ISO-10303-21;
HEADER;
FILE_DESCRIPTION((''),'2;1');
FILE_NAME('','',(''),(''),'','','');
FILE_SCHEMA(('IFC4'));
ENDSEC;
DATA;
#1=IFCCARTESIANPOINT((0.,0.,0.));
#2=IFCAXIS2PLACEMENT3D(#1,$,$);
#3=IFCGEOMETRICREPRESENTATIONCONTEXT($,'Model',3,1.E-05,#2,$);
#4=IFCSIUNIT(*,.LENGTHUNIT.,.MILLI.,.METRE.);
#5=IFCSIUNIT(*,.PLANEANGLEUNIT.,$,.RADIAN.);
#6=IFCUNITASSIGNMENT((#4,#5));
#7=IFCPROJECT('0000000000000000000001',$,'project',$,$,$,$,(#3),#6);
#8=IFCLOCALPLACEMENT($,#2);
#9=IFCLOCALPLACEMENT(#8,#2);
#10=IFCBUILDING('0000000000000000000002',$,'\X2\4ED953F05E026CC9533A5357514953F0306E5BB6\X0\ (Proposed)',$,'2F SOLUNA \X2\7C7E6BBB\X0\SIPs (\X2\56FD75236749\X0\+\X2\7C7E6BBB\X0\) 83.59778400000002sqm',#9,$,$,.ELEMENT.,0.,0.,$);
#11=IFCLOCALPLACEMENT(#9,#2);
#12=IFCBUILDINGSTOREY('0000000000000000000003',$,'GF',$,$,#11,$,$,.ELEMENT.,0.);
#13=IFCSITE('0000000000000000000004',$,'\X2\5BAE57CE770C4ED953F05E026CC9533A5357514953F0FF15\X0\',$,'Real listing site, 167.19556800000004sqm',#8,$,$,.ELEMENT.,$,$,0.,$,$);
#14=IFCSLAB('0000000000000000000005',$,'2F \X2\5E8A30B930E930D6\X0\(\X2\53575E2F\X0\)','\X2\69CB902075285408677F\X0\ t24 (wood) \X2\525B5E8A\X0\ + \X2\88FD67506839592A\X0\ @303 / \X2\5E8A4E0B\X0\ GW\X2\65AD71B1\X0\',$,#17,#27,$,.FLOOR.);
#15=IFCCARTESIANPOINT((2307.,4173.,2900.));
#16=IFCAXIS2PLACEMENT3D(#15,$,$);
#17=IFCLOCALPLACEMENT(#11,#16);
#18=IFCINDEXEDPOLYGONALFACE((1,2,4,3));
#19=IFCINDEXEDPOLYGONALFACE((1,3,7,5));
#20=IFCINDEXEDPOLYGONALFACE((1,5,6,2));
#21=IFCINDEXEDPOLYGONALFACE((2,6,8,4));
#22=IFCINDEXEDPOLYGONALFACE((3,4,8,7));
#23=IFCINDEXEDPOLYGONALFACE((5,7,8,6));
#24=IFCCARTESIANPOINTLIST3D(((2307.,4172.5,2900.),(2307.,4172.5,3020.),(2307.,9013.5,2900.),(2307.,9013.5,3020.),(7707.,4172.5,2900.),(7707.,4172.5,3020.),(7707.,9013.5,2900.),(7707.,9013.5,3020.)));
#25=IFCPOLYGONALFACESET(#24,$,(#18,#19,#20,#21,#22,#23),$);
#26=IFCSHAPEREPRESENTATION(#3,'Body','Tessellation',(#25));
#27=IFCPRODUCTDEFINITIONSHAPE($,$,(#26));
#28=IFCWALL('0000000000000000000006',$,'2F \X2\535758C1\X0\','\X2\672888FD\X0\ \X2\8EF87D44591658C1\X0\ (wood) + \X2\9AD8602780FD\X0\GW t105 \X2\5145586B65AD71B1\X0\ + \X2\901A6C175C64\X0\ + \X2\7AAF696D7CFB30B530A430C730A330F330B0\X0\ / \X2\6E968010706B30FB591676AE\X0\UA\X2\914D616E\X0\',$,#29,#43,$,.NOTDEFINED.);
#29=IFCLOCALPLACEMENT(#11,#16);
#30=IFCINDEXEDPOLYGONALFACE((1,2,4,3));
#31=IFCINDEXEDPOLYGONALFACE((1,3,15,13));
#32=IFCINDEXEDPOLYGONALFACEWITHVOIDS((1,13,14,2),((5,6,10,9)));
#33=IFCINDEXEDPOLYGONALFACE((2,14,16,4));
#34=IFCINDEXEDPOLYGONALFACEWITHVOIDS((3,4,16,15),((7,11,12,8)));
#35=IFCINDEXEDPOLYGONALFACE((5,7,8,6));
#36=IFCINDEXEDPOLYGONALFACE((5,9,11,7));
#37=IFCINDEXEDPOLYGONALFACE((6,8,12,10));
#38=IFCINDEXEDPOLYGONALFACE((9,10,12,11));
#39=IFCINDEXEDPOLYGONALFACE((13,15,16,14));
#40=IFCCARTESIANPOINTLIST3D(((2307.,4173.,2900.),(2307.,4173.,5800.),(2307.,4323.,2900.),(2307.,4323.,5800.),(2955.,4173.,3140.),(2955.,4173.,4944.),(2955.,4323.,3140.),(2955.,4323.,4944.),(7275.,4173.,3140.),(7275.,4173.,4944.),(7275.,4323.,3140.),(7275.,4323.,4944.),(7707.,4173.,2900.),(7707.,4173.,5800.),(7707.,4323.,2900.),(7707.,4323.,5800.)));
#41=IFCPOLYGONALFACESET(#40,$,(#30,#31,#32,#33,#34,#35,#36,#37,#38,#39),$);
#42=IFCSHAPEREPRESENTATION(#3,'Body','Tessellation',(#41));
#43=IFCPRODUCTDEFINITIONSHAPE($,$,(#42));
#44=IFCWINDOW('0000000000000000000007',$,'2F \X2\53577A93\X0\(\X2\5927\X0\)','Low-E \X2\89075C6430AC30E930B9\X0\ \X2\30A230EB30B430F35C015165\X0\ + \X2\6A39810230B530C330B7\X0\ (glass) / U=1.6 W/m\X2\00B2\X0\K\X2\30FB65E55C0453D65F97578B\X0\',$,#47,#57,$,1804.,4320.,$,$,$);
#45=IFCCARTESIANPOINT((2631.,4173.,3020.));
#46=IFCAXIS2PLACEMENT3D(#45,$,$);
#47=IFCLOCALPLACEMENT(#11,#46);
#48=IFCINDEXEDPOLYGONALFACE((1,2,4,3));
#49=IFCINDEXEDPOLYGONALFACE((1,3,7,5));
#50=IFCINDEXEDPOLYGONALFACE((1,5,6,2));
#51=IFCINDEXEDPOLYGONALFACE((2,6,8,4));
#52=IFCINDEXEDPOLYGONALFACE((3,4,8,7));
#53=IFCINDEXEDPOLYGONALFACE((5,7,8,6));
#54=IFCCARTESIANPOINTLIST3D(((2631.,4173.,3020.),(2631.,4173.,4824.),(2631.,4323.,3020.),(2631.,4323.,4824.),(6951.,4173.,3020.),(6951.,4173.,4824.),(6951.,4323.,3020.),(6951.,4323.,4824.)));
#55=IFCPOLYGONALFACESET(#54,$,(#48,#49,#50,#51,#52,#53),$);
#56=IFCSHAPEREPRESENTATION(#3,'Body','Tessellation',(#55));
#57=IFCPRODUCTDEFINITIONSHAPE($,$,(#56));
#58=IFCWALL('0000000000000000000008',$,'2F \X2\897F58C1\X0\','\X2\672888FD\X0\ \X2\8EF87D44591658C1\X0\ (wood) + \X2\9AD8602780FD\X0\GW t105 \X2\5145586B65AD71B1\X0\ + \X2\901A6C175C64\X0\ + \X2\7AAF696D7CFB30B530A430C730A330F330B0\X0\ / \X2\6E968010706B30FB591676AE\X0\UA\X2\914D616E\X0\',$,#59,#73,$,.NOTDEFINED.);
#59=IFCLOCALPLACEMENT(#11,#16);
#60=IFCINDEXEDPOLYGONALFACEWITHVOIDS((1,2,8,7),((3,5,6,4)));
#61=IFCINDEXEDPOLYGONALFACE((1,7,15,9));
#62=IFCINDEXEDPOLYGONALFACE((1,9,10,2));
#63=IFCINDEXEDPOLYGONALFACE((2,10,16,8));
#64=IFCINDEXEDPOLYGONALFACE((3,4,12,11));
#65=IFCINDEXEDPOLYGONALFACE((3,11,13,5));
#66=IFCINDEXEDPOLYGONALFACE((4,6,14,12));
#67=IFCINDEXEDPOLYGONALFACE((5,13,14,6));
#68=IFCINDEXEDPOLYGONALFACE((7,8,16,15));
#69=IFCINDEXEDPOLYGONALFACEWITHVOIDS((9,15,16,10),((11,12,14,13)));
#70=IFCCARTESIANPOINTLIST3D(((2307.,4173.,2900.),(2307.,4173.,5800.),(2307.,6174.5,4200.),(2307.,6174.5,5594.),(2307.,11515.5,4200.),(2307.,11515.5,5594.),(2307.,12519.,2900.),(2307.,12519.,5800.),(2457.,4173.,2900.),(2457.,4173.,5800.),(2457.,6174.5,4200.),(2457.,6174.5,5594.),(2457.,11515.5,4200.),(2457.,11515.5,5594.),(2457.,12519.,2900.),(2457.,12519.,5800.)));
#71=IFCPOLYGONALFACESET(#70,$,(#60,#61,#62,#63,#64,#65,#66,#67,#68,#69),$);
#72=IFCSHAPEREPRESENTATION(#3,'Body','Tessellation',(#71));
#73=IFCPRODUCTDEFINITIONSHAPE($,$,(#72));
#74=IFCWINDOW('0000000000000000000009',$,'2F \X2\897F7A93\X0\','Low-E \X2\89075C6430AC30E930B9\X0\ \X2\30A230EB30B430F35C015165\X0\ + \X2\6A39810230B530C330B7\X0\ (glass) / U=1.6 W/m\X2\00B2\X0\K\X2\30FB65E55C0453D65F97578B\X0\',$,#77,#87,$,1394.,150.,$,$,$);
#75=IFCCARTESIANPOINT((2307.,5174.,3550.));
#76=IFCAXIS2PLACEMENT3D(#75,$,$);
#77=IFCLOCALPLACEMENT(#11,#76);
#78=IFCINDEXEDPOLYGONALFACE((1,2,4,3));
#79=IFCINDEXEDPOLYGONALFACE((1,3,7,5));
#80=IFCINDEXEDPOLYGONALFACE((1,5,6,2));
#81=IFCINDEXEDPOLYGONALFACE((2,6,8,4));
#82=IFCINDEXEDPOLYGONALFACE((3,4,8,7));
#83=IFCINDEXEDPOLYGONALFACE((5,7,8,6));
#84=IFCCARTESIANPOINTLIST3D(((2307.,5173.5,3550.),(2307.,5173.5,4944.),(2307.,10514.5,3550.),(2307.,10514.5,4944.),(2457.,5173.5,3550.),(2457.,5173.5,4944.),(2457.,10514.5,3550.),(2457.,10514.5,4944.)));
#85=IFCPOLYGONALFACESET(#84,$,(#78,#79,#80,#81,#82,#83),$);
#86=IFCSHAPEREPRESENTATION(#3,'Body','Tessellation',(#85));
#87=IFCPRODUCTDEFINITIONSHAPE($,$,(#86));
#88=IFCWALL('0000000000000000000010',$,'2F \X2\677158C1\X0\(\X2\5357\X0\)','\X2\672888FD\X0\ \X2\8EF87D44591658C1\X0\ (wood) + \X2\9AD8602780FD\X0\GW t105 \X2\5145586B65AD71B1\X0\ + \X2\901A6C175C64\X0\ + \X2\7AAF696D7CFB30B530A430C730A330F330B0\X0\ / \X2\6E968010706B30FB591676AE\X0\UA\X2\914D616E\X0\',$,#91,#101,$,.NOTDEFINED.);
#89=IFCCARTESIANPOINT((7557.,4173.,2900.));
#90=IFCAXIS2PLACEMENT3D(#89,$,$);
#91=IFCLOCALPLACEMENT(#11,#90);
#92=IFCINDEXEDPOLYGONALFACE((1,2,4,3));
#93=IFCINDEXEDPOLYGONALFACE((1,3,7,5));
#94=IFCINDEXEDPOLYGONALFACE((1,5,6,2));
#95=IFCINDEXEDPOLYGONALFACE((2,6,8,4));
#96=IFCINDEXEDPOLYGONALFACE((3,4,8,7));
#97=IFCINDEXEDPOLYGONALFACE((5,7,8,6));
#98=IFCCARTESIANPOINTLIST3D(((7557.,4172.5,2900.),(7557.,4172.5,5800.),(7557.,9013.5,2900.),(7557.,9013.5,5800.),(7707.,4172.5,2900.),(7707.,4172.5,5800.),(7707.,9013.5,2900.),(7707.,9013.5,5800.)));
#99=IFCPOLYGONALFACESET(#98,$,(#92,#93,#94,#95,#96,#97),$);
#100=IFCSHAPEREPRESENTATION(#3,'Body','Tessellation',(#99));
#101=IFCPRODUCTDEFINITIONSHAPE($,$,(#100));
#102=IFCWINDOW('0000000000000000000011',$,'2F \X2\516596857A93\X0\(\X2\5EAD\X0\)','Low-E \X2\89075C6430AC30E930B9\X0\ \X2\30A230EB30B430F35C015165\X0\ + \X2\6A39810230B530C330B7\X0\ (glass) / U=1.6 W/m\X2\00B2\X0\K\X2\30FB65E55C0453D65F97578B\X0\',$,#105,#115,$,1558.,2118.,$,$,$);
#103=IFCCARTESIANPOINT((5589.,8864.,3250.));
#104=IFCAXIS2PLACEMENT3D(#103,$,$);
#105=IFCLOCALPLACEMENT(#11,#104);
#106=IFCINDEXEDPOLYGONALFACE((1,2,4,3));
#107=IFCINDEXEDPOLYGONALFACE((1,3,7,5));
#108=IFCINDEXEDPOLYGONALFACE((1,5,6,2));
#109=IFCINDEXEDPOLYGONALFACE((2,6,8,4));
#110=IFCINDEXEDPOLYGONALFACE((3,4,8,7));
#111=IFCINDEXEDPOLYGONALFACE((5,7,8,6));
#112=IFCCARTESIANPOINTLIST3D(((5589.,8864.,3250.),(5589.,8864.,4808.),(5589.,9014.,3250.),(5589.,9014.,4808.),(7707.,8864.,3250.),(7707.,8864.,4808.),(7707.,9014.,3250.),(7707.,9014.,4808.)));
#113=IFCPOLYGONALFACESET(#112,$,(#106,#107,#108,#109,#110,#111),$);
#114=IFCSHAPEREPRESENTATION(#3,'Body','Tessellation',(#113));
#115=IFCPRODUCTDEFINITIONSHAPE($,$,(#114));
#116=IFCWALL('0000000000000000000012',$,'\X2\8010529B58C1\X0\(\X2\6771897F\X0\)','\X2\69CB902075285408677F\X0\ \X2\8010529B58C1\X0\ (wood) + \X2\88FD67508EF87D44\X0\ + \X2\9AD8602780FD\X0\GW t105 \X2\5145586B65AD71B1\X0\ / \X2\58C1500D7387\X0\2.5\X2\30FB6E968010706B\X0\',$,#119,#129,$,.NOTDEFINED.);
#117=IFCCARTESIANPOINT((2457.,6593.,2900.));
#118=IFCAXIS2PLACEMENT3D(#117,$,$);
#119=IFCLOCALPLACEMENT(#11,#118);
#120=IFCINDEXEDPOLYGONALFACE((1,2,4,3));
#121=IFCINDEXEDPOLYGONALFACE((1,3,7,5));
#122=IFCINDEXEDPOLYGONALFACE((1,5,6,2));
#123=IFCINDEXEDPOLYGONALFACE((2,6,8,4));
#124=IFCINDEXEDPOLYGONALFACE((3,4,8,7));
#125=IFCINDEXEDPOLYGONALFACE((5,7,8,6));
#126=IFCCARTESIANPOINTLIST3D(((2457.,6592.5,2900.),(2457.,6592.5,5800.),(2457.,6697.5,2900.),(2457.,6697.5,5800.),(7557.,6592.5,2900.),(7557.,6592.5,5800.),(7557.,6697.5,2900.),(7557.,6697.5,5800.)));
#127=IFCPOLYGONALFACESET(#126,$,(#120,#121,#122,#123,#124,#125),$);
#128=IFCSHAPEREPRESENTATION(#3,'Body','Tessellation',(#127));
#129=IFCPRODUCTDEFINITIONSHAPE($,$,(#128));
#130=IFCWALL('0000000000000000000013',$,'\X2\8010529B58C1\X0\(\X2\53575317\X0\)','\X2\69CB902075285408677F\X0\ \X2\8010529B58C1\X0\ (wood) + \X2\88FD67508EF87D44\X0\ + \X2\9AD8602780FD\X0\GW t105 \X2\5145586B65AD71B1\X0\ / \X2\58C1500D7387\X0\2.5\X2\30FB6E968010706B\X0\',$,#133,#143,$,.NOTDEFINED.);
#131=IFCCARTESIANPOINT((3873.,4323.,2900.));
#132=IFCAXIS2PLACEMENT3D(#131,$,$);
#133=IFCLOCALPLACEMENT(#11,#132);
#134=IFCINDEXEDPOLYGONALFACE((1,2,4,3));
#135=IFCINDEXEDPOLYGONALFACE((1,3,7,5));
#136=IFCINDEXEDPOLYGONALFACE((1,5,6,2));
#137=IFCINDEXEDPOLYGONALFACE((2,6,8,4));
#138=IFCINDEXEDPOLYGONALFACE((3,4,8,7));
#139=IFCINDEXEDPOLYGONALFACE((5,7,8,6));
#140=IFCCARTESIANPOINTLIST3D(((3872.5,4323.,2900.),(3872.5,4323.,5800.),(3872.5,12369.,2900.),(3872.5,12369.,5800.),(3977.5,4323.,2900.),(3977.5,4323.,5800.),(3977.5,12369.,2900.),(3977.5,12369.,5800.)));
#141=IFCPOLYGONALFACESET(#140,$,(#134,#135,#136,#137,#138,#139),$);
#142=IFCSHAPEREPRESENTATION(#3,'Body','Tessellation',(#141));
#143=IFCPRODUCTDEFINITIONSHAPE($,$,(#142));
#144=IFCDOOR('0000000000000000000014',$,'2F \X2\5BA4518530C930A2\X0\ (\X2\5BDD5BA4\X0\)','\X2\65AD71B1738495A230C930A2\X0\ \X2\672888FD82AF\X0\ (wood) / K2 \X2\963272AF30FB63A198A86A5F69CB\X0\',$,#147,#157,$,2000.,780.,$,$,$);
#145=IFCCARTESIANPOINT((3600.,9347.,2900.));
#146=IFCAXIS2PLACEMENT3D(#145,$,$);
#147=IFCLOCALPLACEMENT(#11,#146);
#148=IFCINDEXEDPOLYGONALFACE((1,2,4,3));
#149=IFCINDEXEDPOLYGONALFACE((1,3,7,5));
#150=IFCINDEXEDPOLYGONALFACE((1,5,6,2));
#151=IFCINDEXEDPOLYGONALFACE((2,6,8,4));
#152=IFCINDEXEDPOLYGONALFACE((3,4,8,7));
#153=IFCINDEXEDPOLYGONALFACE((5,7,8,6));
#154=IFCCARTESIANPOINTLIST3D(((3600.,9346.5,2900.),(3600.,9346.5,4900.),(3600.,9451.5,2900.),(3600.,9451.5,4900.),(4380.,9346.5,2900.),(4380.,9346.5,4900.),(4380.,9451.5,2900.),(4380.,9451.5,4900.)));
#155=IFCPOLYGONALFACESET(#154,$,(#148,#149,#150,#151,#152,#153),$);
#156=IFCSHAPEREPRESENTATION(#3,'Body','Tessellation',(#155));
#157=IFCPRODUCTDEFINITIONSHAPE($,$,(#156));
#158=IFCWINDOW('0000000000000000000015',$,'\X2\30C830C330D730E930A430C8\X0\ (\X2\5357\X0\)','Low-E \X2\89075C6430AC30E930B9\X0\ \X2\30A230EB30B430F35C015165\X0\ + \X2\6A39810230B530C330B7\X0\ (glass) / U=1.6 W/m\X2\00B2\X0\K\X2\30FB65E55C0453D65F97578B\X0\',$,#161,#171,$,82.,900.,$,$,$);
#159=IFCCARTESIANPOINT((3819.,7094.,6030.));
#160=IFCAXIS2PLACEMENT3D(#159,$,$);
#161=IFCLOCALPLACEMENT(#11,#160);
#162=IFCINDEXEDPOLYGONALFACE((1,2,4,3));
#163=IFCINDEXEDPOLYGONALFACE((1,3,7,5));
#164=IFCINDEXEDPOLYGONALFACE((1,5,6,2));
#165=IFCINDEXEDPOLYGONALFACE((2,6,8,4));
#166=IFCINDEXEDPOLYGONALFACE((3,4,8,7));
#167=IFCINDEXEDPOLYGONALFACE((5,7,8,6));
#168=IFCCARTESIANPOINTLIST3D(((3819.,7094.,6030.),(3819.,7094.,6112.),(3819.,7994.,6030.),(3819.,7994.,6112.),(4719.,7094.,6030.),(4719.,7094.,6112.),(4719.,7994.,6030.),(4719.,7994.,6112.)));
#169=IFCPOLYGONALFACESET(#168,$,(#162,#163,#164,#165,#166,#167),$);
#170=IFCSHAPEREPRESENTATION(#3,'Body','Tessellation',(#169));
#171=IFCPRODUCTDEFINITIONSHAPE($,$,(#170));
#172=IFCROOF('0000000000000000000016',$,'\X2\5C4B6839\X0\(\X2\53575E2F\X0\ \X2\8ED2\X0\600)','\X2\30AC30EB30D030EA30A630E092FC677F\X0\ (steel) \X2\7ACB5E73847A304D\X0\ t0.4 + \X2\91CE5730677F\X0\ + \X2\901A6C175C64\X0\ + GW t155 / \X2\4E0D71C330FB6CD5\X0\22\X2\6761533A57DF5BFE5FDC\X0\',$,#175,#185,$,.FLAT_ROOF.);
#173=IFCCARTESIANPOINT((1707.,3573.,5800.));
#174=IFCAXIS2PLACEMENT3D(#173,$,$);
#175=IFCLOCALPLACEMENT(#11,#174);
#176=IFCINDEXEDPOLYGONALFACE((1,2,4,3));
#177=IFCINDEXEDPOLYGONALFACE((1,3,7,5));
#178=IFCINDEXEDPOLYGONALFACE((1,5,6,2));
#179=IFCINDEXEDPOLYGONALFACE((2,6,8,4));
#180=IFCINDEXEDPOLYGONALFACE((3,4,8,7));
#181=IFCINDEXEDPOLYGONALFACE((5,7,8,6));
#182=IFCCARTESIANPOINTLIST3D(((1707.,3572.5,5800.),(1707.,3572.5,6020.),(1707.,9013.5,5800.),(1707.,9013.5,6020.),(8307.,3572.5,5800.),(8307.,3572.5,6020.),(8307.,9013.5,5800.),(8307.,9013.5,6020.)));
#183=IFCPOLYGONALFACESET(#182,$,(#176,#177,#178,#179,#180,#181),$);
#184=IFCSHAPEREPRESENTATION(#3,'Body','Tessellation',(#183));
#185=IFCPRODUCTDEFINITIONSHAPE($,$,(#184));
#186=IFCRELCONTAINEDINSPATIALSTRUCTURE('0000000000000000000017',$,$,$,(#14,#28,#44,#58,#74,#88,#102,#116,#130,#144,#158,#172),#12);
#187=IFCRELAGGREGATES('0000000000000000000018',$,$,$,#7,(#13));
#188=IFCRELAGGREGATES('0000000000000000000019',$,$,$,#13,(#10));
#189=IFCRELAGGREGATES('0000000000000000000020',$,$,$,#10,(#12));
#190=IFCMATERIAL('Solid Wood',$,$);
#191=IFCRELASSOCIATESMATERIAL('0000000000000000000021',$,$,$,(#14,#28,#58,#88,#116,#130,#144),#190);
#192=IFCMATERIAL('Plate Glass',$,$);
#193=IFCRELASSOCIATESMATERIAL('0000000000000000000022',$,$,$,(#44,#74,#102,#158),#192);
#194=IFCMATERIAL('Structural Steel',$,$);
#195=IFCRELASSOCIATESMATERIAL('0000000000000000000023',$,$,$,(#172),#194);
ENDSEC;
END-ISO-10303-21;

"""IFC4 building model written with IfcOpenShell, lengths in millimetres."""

from ifc_helpers import new_model, si_unit, frame, frame_2d, origin, place, context, project, spatial, rectangle, extrude, material, element, fill, save


model = new_model("IFC4")

# Units and contexts
model_context = context("Model", 3, precision=1e-05, world=origin())
ifc_project = project(units=[si_unit("LENGTHUNIT", "METRE", prefix="MILLI"), si_unit("PLANEANGLEUNIT", "RADIAN")], contexts=[model_context])

# Site, building, storey
site_placement = place(None, origin())
site = spatial("IfcSite", under=ifc_project, at=site_placement, Name="宮城県仙台市泉区南光台５", ObjectType="Real listing site, 167.19556800000004sqm", CompositionType="ELEMENT", RefElevation=0.0)
building_placement = place(site_placement, origin())
building = spatial("IfcBuilding", under=site, at=building_placement, Name="仙台市泉区南光台の家 (Proposed)", ObjectType="2F SOLUNA 籾殻SIPs (国産杉+籾殻) 83.59778400000002sqm", CompositionType="ELEMENT", ElevationOfRefHeight=0.0, ElevationOfTerrain=0.0)
storey_placement = place(building_placement, origin())
storey = spatial("IfcBuildingStorey", under=building, at=storey_placement, Name="GF", CompositionType="ELEMENT", Elevation=0.0)

# Slab
ifc_material_1 = material(Name="Solid Wood")
slab_placement = place(storey_placement, frame((2307.0, 4173.0, 2900.0)))
element("IfcSlab", 1, at=slab_placement, inside=storey, material=ifc_material_1, Name="2F 床スラブ(南帯)", Description="構造用合板 t24 (wood) 剛床 + 製材根太 @303 / 床下 GW断熱", PredefinedType="FLOOR", context=model_context, shape_type="SweptSolid", body=[
    extrude(rectangle(XDim=5400.0, YDim=4841.0, at=frame_2d((2700.0, 2420.0))), frame((2307.0, 4173.0, 2900.0)), (0.0, 0.0, 1.0), 120.0),
])

# Walls, openings, windows
wall_1_placement = place(storey_placement, frame((2307.0, 4173.0, 2900.0)))
wall_1 = element("IfcWall", 2, at=wall_1_placement, inside=storey, material=ifc_material_1, Name="2F 南壁", Description="木製 軸組外壁 (wood) + 高性能GW t105 充填断熱 + 通気層 + 窯業系サイディング / 準耐火・外皮UA配慮", PredefinedType="NOTDEFINED", context=model_context, shape_type="SweptSolid", body=[
    extrude(rectangle(XDim=5400.0, YDim=150.0, at=frame_2d((2700.0, 75.0))), frame((2307.0, 4173.0, 2900.0)), (0.0, 0.0, 1.0), 2900.0),
])
opening_1_placement = place(storey_placement, frame((2631.0, 4173.0, 3020.0)))
opening_1 = element("IfcOpeningElement", 3, at=opening_1_placement, cuts=wall_1, PredefinedType="NOTDEFINED", context=model_context, shape_type="SweptSolid", body=[
    extrude(rectangle(XDim=4320.0, YDim=150.0, at=frame_2d((2160.0, 75.0))), frame((2631.0, 4173.0, 3020.0)), (0.0, 0.0, 1.0), 1804.0),
])
ifc_material_2 = material(Name="Plate Glass")
window_1_placement = place(storey_placement, frame((2631.0, 4173.0, 3020.0)))
window_1 = element("IfcWindow", 4, at=window_1_placement, inside=storey, material=ifc_material_2, Name="2F 南窓(大)", Description="Low-E 複層ガラス アルゴン封入 + 樹脂サッシ (glass) / U=1.6 W/m²K・日射取得型", OverallHeight=1804.0, OverallWidth=4320.0, context=model_context, shape_type="SweptSolid", body=[
    extrude(rectangle(XDim=4320.0, YDim=150.0, at=frame_2d((2160.0, 75.0))), frame((2631.0, 4173.0, 3020.0)), (0.0, 0.0, 1.0), 1804.0),
])
fill(opening_1, window_1)
wall_2_placement = place(storey_placement, frame((2307.0, 4173.0, 2900.0)))
wall_2 = element("IfcWall", 5, at=wall_2_placement, inside=storey, material=ifc_material_1, Name="2F 西壁", Description="木製 軸組外壁 (wood) + 高性能GW t105 充填断熱 + 通気層 + 窯業系サイディング / 準耐火・外皮UA配慮", PredefinedType="NOTDEFINED", context=model_context, shape_type="SweptSolid", body=[
    extrude(rectangle(XDim=150.0, YDim=8346.0, at=frame_2d((75.0, 4173.0))), frame((2307.0, 4173.0, 2900.0)), (0.0, 0.0, 1.0), 2900.0),
])
opening_2_placement = place(storey_placement, frame((2307.0, 5174.0, 3550.0)))
opening_2 = element("IfcOpeningElement", 6, at=opening_2_placement, cuts=wall_2, PredefinedType="NOTDEFINED", context=model_context, shape_type="SweptSolid", body=[
    extrude(rectangle(XDim=150.0, YDim=5341.0, at=frame_2d((75.0, 2670.0))), frame((2307.0, 5174.0, 3550.0)), (0.0, 0.0, 1.0), 1394.0),
])
window_2_placement = place(storey_placement, frame((2307.0, 5174.0, 3550.0)))
window_2 = element("IfcWindow", 7, at=window_2_placement, inside=storey, material=ifc_material_2, Name="2F 西窓", Description="Low-E 複層ガラス アルゴン封入 + 樹脂サッシ (glass) / U=1.6 W/m²K・日射取得型", OverallHeight=1394.0, OverallWidth=150.0, context=model_context, shape_type="SweptSolid", body=[
    extrude(rectangle(XDim=150.0, YDim=5341.0, at=frame_2d((75.0, 2670.0))), frame((2307.0, 5174.0, 3550.0)), (0.0, 0.0, 1.0), 1394.0),
])
fill(opening_2, window_2)
wall_3_placement = place(storey_placement, frame((7557.0, 4173.0, 2900.0)))
wall_3 = element("IfcWall", 8, at=wall_3_placement, inside=storey, material=ifc_material_1, Name="2F 東壁(南)", Description="木製 軸組外壁 (wood) + 高性能GW t105 充填断熱 + 通気層 + 窯業系サイディング / 準耐火・外皮UA配慮", PredefinedType="NOTDEFINED", context=model_context, shape_type="SweptSolid", body=[
    extrude(rectangle(XDim=150.0, YDim=4841.0, at=frame_2d((75.0, 2420.0))), frame((7557.0, 4173.0, 2900.0)), (0.0, 0.0, 1.0), 2900.0),
])
opening_3_placement = place(storey_placement, frame((5589.0, 8864.0, 3250.0)))
opening_3 = element("IfcOpeningElement", 9, at=opening_3_placement, cuts=wall_3, PredefinedType="NOTDEFINED", context=model_context, shape_type="SweptSolid", body=[
    extrude(rectangle(XDim=2118.0, YDim=150.0, at=frame_2d((1059.0, 75.0))), frame((5589.0, 8864.0, 3250.0)), (0.0, 0.0, 1.0), 1558.0),
])
window_3_placement = place(storey_placement, frame((5589.0, 8864.0, 3250.0)))
window_3 = element("IfcWindow", 10, at=window_3_placement, inside=storey, material=ifc_material_2, Name="2F 入隅窓(庭)", Description="Low-E 複層ガラス アルゴン封入 + 樹脂サッシ (glass) / U=1.6 W/m²K・日射取得型", OverallHeight=1558.0, OverallWidth=2118.0, context=model_context, shape_type="SweptSolid", body=[
    extrude(rectangle(XDim=2118.0, YDim=150.0, at=frame_2d((1059.0, 75.0))), frame((5589.0, 8864.0, 3250.0)), (0.0, 0.0, 1.0), 1558.0),
])
fill(opening_3, window_3)

# Wall
wall_4_placement = place(storey_placement, frame((2457.0, 6593.0, 2900.0)))
element("IfcWall", 11, at=wall_4_placement, inside=storey, material=ifc_material_1, Name="耐力壁(東西)", Description="構造用合板 耐力壁 (wood) + 製材軸組 + 高性能GW t105 充填断熱 / 壁倍率2.5・準耐火", PredefinedType="NOTDEFINED", context=model_context, shape_type="SweptSolid", body=[
    extrude(rectangle(XDim=5100.0, YDim=105.0, at=frame_2d((2550.0, 52.0))), frame((2457.0, 6593.0, 2900.0)), (0.0, 0.0, 1.0), 2900.0),
])

# Wall, opening, door
wall_5_placement = place(storey_placement, frame((3873.0, 4323.0, 2900.0)))
wall_5 = element("IfcWall", 12, at=wall_5_placement, inside=storey, material=ifc_material_1, Name="耐力壁(南北)", Description="構造用合板 耐力壁 (wood) + 製材軸組 + 高性能GW t105 充填断熱 / 壁倍率2.5・準耐火", PredefinedType="NOTDEFINED", context=model_context, shape_type="SweptSolid", body=[
    extrude(rectangle(XDim=105.0, YDim=8046.0, at=frame_2d((52.0, 4023.0))), frame((3873.0, 4323.0, 2900.0)), (0.0, 0.0, 1.0), 2900.0),
])
opening_4_placement = place(storey_placement, frame((3600.0, 9347.0, 2900.0)))
opening_4 = element("IfcOpeningElement", 13, at=opening_4_placement, cuts=wall_5, PredefinedType="NOTDEFINED", context=model_context, shape_type="SweptSolid", body=[
    extrude(rectangle(XDim=780.0, YDim=105.0, at=frame_2d((390.0, 52.0))), frame((3600.0, 9347.0, 2900.0)), (0.0, 0.0, 1.0), 2000.0),
])
door_placement = place(storey_placement, frame((3600.0, 9347.0, 2900.0)))
door = element("IfcDoor", 14, at=door_placement, inside=storey, material=ifc_material_1, Name="2F 室内ドア (寝室)", Description="断熱玄関ドア 木製芯 (wood) / K2 防犯・採風機構", OverallHeight=2000.0, OverallWidth=780.0, context=model_context, shape_type="SweptSolid", body=[
    extrude(rectangle(XDim=780.0, YDim=105.0, at=frame_2d((390.0, 52.0))), frame((3600.0, 9347.0, 2900.0)), (0.0, 0.0, 1.0), 2000.0),
])
fill(opening_4, door)

# Window
window_4_placement = place(storey_placement, frame((3819.0, 7094.0, 6030.0)))
element("IfcWindow", 15, at=window_4_placement, inside=storey, material=ifc_material_2, Name="トップライト (南)", Description="Low-E 複層ガラス アルゴン封入 + 樹脂サッシ (glass) / U=1.6 W/m²K・日射取得型", OverallHeight=82.0, OverallWidth=900.0, context=model_context, shape_type="SweptSolid", body=[
    extrude(rectangle(XDim=900.0, YDim=900.0, at=frame_2d((450.0, 450.0))), frame((3819.0, 7094.0, 6030.0)), (0.0, 0.0, 1.0), 82.0),
])

# Roof
ifc_material_3 = material(Name="Structural Steel")
for number, where, name in (
    (16, (1707.0, 3573.0, 5800.0), "屋根(南帯 軒600)"),
):
    element("IfcRoof", number, at=place(storey_placement, frame(where)), inside=storey, material=ifc_material_3, Name=name, Description="ガルバリウム鋼板 (steel) 立平葺き t0.4 + 野地板 + 通気層 + GW t155 / 不燃・法22条区域対応", PredefinedType="FLAT_ROOF", context=model_context, shape_type="SweptSolid", body=[
        extrude(rectangle(XDim=6600.0, YDim=5441.0, at=frame_2d((3300.0, 2720.0))), frame((1707.0, 3573.0, 5800.0)), (0.0, 0.0, 1.0), 220.0),
    ])

save(model, "model.ifc")
